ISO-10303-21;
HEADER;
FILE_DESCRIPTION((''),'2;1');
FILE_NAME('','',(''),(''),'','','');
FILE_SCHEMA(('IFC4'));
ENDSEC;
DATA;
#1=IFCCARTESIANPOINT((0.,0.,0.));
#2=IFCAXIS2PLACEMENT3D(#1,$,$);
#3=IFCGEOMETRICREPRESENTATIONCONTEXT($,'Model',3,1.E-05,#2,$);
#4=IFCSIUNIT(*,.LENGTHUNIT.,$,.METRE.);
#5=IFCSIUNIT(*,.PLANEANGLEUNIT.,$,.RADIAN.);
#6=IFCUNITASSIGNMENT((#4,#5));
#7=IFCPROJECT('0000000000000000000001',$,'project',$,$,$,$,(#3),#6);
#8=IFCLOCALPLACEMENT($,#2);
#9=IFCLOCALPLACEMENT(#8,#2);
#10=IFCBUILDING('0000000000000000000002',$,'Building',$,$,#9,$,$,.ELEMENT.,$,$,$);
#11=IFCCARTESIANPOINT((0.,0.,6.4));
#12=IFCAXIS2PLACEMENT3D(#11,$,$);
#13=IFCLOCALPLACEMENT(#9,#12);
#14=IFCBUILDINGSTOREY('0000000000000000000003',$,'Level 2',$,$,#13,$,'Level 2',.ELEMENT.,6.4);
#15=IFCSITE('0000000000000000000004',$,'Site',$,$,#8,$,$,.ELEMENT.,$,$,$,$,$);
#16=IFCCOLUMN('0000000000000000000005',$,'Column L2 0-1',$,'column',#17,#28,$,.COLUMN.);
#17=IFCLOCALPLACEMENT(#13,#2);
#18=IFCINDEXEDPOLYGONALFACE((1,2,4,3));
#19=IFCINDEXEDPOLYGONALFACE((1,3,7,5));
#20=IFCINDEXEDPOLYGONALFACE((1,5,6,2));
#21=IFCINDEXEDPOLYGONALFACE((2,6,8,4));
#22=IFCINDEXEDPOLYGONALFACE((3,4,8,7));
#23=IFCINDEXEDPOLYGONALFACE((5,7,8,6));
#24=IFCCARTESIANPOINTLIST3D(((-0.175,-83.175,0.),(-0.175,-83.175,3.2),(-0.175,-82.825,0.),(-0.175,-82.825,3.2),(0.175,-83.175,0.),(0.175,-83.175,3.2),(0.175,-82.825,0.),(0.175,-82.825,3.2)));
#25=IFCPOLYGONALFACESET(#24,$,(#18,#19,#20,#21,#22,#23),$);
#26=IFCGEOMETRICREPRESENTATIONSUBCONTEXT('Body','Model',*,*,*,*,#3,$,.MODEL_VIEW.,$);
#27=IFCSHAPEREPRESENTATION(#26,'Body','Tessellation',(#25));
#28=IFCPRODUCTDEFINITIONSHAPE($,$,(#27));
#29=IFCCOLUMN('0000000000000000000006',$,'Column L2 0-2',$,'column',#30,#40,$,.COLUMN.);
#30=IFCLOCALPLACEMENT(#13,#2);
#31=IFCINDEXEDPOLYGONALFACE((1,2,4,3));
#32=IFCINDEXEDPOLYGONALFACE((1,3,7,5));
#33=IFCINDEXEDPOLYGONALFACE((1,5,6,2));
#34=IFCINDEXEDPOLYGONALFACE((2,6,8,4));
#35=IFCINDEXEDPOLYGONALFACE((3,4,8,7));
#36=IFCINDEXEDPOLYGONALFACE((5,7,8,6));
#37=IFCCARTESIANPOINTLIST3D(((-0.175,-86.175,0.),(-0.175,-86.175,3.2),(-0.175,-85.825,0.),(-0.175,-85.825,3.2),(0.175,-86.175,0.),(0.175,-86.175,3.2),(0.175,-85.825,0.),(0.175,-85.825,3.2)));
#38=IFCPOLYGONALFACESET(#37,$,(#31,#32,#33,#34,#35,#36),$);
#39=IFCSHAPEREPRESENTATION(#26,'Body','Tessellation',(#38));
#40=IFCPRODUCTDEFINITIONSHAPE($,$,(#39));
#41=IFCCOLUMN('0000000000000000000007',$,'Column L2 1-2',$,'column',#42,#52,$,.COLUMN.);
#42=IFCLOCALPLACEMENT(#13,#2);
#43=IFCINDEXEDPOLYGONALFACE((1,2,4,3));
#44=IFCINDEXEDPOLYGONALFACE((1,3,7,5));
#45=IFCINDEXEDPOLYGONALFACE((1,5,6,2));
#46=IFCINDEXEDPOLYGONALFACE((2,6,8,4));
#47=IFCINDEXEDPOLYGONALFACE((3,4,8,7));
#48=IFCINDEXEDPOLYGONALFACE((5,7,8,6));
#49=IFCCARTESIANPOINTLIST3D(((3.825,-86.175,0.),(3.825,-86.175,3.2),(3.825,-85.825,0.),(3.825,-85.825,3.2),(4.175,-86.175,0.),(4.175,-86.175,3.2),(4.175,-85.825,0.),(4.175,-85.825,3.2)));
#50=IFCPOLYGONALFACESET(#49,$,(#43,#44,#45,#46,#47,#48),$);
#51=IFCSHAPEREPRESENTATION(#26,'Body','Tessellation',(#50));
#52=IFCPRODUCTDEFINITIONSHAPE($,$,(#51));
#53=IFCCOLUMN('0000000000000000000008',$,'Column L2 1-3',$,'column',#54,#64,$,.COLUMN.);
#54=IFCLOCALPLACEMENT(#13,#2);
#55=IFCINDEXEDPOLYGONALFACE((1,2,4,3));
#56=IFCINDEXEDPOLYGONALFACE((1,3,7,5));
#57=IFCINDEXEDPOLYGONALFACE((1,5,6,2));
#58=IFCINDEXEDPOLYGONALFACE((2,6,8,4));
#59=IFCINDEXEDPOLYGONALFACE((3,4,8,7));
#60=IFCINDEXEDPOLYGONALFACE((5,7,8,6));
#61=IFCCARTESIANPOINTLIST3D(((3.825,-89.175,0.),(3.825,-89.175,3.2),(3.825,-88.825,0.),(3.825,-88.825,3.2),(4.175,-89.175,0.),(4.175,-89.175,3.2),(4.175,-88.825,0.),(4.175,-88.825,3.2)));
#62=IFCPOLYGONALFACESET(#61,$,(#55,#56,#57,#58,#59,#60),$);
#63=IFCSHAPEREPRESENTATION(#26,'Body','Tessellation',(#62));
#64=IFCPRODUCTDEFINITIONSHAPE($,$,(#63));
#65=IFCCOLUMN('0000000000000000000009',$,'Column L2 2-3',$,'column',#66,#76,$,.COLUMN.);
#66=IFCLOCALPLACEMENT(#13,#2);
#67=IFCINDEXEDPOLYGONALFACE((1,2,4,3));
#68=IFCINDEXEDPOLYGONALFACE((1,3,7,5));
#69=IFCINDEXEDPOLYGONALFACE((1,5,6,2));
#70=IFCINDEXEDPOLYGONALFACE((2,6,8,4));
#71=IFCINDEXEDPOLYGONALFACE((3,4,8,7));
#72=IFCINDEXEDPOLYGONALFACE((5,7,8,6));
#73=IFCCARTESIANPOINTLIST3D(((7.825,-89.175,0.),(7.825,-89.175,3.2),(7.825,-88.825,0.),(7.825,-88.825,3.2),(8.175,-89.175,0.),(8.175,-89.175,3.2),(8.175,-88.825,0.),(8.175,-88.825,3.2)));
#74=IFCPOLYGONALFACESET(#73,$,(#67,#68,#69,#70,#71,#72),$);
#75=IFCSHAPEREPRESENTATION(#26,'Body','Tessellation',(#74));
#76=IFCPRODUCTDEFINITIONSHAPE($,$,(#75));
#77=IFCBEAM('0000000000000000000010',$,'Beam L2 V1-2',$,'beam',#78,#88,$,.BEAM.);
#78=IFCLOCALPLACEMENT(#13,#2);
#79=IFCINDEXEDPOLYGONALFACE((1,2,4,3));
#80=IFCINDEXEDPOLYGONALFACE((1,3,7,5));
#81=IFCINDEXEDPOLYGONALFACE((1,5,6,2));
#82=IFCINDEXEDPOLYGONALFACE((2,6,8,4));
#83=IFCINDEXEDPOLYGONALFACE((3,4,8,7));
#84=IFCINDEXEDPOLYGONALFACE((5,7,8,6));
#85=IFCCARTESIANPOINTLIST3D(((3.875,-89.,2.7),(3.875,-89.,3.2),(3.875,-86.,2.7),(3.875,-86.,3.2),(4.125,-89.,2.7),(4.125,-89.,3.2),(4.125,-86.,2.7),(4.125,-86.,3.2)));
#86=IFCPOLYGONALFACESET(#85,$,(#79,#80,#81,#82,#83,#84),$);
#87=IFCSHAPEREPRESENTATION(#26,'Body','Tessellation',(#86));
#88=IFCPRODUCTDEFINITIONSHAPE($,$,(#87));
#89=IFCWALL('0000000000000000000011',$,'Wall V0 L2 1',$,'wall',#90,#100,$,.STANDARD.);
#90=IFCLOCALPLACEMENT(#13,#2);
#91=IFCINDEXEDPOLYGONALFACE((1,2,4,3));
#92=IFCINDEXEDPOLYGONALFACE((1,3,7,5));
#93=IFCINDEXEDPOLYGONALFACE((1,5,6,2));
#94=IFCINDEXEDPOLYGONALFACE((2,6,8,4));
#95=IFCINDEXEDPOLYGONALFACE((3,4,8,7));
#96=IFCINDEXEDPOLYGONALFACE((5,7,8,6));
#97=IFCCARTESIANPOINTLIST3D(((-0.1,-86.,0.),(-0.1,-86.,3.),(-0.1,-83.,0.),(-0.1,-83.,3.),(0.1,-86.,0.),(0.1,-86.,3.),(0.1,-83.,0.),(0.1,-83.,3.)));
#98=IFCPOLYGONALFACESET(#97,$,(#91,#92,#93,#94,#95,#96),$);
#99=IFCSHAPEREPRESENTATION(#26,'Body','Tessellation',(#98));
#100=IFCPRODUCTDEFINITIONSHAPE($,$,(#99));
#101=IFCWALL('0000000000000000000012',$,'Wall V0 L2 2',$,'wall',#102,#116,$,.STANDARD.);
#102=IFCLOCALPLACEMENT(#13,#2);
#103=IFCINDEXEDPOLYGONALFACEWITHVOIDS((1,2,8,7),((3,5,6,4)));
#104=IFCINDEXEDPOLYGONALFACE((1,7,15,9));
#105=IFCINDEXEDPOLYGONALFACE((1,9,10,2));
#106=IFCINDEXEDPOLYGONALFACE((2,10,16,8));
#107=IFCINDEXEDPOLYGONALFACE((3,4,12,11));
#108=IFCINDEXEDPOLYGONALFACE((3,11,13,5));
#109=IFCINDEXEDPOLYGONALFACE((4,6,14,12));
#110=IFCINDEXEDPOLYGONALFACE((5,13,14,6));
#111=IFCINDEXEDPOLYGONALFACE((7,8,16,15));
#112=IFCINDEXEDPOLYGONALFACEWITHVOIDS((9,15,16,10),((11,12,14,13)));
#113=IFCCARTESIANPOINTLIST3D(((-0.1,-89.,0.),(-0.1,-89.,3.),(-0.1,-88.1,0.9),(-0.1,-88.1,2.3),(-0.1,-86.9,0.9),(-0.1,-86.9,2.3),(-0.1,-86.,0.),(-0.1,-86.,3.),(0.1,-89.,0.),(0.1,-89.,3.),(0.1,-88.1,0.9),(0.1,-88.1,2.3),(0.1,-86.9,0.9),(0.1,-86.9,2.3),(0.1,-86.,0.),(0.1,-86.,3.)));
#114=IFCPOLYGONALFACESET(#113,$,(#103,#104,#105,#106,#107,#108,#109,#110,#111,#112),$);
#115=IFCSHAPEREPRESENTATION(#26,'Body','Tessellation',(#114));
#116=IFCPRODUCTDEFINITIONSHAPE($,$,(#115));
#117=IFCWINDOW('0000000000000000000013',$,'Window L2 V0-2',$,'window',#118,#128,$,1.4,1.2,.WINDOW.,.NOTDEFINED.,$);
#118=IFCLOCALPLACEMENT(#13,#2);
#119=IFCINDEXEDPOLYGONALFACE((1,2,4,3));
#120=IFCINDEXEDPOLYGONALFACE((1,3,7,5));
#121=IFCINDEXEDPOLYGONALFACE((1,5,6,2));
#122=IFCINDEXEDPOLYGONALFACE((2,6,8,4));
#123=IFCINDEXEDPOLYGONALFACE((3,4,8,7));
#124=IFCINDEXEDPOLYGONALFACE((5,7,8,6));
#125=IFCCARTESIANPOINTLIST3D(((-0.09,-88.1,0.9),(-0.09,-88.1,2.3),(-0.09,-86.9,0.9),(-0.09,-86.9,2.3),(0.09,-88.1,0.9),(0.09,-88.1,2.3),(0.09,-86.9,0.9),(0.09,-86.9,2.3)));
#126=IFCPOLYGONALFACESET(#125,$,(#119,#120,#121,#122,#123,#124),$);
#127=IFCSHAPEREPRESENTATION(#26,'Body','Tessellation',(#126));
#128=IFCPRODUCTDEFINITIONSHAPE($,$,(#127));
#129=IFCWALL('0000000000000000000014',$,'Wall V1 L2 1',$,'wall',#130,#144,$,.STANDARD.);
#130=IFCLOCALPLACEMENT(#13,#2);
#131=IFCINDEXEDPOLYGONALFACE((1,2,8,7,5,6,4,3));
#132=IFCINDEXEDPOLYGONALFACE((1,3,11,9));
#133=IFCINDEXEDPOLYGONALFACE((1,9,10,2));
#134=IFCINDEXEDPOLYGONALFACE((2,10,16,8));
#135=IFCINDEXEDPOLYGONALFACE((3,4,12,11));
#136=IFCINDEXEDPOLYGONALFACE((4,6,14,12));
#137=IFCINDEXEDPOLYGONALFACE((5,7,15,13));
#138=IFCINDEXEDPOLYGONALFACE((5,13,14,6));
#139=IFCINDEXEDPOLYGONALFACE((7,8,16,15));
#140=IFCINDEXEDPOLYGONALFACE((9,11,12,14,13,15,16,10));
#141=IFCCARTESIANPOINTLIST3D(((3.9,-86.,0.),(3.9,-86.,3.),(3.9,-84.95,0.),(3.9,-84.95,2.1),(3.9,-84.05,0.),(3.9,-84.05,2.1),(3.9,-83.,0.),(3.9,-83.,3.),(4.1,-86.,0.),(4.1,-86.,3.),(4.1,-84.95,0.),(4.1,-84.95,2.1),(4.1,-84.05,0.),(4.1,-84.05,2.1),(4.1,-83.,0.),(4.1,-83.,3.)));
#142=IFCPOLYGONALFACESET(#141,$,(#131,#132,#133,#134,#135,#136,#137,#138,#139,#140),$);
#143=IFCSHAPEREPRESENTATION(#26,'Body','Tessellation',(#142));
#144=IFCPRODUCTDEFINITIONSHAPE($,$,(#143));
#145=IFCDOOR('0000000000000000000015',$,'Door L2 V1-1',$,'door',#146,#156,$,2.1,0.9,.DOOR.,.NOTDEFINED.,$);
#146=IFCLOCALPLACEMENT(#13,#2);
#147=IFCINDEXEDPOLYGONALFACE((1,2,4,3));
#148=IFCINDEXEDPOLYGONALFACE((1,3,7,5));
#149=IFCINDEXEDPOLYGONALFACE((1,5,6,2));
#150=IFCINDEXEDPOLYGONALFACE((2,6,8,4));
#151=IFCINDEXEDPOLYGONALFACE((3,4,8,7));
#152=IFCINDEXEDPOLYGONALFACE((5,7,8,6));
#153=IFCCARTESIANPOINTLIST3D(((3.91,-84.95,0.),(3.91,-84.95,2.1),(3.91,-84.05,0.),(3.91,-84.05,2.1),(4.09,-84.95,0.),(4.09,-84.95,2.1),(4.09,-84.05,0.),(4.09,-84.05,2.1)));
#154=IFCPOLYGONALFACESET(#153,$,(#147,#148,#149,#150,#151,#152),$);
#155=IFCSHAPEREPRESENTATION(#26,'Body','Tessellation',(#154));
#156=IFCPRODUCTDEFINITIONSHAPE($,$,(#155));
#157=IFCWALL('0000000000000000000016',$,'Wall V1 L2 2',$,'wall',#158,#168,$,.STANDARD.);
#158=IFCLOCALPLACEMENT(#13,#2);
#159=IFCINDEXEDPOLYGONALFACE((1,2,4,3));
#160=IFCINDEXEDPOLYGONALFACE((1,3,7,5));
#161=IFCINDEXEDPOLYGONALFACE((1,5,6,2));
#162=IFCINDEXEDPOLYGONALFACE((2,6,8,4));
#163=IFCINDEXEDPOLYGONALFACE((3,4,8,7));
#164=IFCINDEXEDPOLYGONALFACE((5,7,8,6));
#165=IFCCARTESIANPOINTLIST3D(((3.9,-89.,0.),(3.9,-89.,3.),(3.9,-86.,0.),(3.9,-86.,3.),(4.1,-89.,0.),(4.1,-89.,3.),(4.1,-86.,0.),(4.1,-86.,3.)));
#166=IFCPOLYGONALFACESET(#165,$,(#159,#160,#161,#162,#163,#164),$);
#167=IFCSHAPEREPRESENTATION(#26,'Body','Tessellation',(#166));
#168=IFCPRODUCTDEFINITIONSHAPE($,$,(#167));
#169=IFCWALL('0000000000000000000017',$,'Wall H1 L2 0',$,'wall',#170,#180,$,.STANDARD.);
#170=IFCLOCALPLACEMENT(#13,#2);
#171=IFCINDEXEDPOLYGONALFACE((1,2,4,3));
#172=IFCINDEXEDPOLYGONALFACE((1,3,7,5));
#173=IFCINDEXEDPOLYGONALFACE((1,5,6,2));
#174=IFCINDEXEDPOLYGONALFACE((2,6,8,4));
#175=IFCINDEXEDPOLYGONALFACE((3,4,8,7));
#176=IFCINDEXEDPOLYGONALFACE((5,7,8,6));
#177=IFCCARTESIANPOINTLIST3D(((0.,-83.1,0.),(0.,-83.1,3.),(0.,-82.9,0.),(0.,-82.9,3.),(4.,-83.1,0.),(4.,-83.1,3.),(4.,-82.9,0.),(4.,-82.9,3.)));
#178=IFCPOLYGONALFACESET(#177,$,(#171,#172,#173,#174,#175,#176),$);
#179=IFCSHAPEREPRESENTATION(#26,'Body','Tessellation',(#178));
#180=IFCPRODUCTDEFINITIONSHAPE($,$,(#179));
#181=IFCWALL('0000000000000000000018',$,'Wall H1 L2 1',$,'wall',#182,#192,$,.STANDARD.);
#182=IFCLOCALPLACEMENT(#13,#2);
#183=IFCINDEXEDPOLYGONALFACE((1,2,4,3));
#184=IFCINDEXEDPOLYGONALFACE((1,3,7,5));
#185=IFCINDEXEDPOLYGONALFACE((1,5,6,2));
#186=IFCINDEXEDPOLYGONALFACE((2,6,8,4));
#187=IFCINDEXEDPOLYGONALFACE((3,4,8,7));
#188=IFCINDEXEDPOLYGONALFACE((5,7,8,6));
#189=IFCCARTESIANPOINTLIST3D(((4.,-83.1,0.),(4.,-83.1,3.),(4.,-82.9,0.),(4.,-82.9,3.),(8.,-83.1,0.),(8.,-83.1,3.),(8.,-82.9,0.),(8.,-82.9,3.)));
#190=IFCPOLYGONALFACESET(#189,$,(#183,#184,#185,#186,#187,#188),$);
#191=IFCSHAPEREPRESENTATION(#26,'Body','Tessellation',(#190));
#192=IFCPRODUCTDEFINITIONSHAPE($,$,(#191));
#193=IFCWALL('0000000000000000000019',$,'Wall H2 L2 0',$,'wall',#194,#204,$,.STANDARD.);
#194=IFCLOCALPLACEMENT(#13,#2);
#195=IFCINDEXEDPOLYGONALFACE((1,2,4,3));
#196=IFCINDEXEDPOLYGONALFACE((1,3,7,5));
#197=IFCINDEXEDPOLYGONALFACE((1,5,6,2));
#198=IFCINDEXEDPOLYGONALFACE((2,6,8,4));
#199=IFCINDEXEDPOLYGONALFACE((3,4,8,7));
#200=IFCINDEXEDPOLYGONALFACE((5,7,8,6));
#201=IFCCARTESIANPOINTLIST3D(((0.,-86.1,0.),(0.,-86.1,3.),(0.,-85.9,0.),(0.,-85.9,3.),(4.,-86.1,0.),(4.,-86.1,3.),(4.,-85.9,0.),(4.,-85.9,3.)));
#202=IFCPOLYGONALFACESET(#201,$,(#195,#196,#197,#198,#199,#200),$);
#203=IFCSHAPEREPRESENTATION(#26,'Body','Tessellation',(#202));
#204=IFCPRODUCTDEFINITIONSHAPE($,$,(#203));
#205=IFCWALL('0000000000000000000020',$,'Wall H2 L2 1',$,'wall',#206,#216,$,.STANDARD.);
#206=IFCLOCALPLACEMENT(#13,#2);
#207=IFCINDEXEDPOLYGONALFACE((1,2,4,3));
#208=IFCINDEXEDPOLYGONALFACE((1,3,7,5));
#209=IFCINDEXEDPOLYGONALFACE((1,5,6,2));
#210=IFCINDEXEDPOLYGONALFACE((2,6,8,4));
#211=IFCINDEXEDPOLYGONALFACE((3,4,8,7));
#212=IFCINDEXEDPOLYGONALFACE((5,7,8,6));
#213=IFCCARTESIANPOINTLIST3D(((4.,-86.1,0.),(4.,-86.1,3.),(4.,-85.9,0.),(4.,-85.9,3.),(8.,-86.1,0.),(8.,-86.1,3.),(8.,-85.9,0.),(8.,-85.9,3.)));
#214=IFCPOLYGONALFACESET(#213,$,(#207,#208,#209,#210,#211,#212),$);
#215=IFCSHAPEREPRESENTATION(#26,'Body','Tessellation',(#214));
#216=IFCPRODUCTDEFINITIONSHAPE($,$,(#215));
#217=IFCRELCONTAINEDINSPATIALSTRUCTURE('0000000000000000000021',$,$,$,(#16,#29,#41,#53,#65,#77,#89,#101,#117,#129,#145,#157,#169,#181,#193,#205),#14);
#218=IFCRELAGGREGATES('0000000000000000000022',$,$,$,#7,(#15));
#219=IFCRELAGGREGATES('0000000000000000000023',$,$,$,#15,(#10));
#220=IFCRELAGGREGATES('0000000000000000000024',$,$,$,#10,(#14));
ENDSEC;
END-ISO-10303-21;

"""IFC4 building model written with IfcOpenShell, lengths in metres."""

from ifc_helpers import new_model, si_unit, frame, frame_2d, origin, origin_2d, place, context, subcontext, project, spatial, rectangle, extrude, element, fill, save


model = new_model("IFC4")

# Units and contexts
model_context = context("Model", 3, precision=1e-05, world=origin())
body_context = subcontext(model_context, "Body", "Model", "MODEL_VIEW")
ifc_project = project(units=[si_unit("LENGTHUNIT", "METRE"), si_unit("PLANEANGLEUNIT", "RADIAN")], contexts=[model_context])

# Site, building, storey
site_placement = place(None, origin())
site = spatial("IfcSite", under=ifc_project, at=site_placement, Name="Site", CompositionType="ELEMENT")
building_placement = place(site_placement, origin())
building = spatial("IfcBuilding", under=site, at=building_placement, Name="Building", CompositionType="ELEMENT")
storey_placement = place(building_placement, frame((0.0, 0.0, 6.4)))
storey = spatial("IfcBuildingStorey", under=building, at=storey_placement, Name="Level 2", LongName="Level 2", CompositionType="ELEMENT", Elevation=6.4)

# Columns
for number, where, name in (
    (1, (0.0, -83.0, 0.0), "Column L2 0-1"),
    (2, (0.0, -86.0, 0.0), "Column L2 0-2"),
    (3, (4.0, -86.0, 0.0), "Column L2 1-2"),
    (4, (4.0, -89.0, 0.0), "Column L2 1-3"),
    (5, (8.0, -89.0, 0.0), "Column L2 2-3"),
):
    element("IfcColumn", number, at=place(storey_placement, frame(where)), inside=storey, Name=name, ObjectType="column", PredefinedType="COLUMN", context=body_context, shape_type="SweptSolid", body=[
        extrude(rectangle(XDim=0.35, YDim=0.35, at=origin_2d()), origin(), (0.0, 0.0, 1.0), 3.2),
    ])

# Beam
beam_placement = place(storey_placement, frame((4.0, -86.0, 2.95), z_axis=(0.0, -1.0, 0.0), x_axis=(0.0, 0.0, 1.0)))
element("IfcBeam", 6, at=beam_placement, inside=storey, Name="Beam L2 V1-2", ObjectType="beam", PredefinedType="BEAM", context=body_context, shape_type="SweptSolid", body=[
    extrude(rectangle(XDim=0.5, YDim=0.25, at=origin_2d()), origin(), (0.0, 0.0, 1.0), 3.0),
])

# Wall
wall_1_placement = place(storey_placement, frame((0.0, -83.0, 0.0), z_axis=(0.0, 0.0, 1.0), x_axis=(0.0, -1.0, 0.0)))
element("IfcWall", 7, at=wall_1_placement, inside=storey, Name="Wall V0 L2 1", ObjectType="wall", PredefinedType="STANDARD", context=body_context, shape_type="SweptSolid", body=[
    extrude(rectangle(XDim=3.0, YDim=0.2, at=frame_2d((1.5, 0.0))), origin(), (0.0, 0.0, 1.0), 3.0),
])

# Wall, opening, window
wall_2_placement = place(storey_placement, frame((0.0, -86.0, 0.0), z_axis=(0.0, 0.0, 1.0), x_axis=(0.0, -1.0, 0.0)))
wall_2 = element("IfcWall", 8, at=wall_2_placement, inside=storey, Name="Wall V0 L2 2", ObjectType="wall", PredefinedType="STANDARD", context=body_context, shape_type="SweptSolid", body=[
    extrude(rectangle(XDim=3.0, YDim=0.2, at=frame_2d((1.5, 0.0))), origin(), (0.0, 0.0, 1.0), 3.0),
])
opening_1_placement = place(storey_placement, frame((0.0, -87.5, 0.9), z_axis=(0.0, 0.0, 1.0), x_axis=(0.0, -1.0, 0.0)))
opening_1 = element("IfcOpeningElement", 9, at=opening_1_placement, cuts=wall_2, ObjectType="Opening", PredefinedType="OPENING", context=body_context, shape_type="SweptSolid", body=[
    extrude(rectangle(XDim=1.2, YDim=0.22, at=origin_2d()), origin(), (0.0, 0.0, 1.0), 1.4),
])
window_1_placement = place(storey_placement, frame((0.0, -87.5, 0.9), z_axis=(0.0, 0.0, 1.0), x_axis=(0.0, -1.0, 0.0)))
window_1 = element("IfcWindow", 10, at=window_1_placement, inside=storey, Name="Window L2 V0-2", ObjectType="window", OverallHeight=1.4, OverallWidth=1.2, PartitioningType="NOTDEFINED", PredefinedType="WINDOW", context=body_context, shape_type="SweptSolid", body=[
    extrude(rectangle(XDim=1.2, YDim=0.18, at=origin_2d()), origin(), (0.0, 0.0, 1.0), 1.4),
])
fill(opening_1, window_1)

# Wall, opening, door
wall_3_placement = place(storey_placement, frame((4.0, -83.0, 0.0), z_axis=(0.0, 0.0, 1.0), x_axis=(0.0, -1.0, 0.0)))
wall_3 = element("IfcWall", 11, at=wall_3_placement, inside=storey, Name="Wall V1 L2 1", ObjectType="wall", PredefinedType="STANDARD", context=body_context, shape_type="SweptSolid", body=[
    extrude(rectangle(XDim=3.0, YDim=0.2, at=frame_2d((1.5, 0.0))), origin(), (0.0, 0.0, 1.0), 3.0),
])
opening_2_placement = place(storey_placement, frame((4.0, -84.5, 0.0), z_axis=(0.0, 0.0, 1.0), x_axis=(0.0, -1.0, 0.0)))
opening_2 = element("IfcOpeningElement", 12, at=opening_2_placement, cuts=wall_3, ObjectType="Opening", PredefinedType="OPENING", context=body_context, shape_type="SweptSolid", body=[
    extrude(rectangle(XDim=0.9, YDim=0.22, at=origin_2d()), origin(), (0.0, 0.0, 1.0), 2.1),
])
door_placement = place(storey_placement, frame((4.0, -84.5, 0.0), z_axis=(0.0, 0.0, 1.0), x_axis=(0.0, -1.0, 0.0)))
door = element("IfcDoor", 13, at=door_placement, inside=storey, Name="Door L2 V1-1", ObjectType="door", OperationType="NOTDEFINED", OverallHeight=2.1, OverallWidth=0.9, PredefinedType="DOOR", context=body_context, shape_type="SweptSolid", body=[
    extrude(rectangle(XDim=0.9, YDim=0.18, at=origin_2d()), origin(), (0.0, 0.0, 1.0), 2.1),
])
fill(opening_2, door)

# Walls
wall_4_placement = place(storey_placement, frame((4.0, -86.0, 0.0), z_axis=(0.0, 0.0, 1.0), x_axis=(0.0, -1.0, 0.0)))
element("IfcWall", 14, at=wall_4_placement, inside=storey, Name="Wall V1 L2 2", ObjectType="wall", PredefinedType="STANDARD", context=body_context, shape_type="SweptSolid", body=[
    extrude(rectangle(XDim=3.0, YDim=0.2, at=frame_2d((1.5, 0.0))), origin(), (0.0, 0.0, 1.0), 3.0),
])
for number, where, z_axis, x_axis, name in (
    (15, (0.0, -83.0, 0.0), (0.0, 0.0, 1.0), (1.0, 0.0, 0.0), "Wall H1 L2 0"),
    (16, (4.0, -83.0, 0.0), (0.0, 0.0, 1.0), (1.0, 0.0, 0.0), "Wall H1 L2 1"),
    (17, (0.0, -86.0, 0.0), (0.0, 0.0, 1.0), (1.0, 0.0, 0.0), "Wall H2 L2 0"),
    (18, (4.0, -86.0, 0.0), (0.0, 0.0, 1.0), (1.0, 0.0, 0.0), "Wall H2 L2 1"),
):
    element("IfcWall", number, at=place(storey_placement, frame(where, z_axis=z_axis, x_axis=x_axis)), inside=storey, Name=name, ObjectType="wall", PredefinedType="STANDARD", context=body_context, shape_type="SweptSolid", body=[
        extrude(rectangle(XDim=4.0, YDim=0.2, at=frame_2d((2.0, 0.0))), origin(), (0.0, 0.0, 1.0), 3.0),
    ])

save(model, "model.ifc")
